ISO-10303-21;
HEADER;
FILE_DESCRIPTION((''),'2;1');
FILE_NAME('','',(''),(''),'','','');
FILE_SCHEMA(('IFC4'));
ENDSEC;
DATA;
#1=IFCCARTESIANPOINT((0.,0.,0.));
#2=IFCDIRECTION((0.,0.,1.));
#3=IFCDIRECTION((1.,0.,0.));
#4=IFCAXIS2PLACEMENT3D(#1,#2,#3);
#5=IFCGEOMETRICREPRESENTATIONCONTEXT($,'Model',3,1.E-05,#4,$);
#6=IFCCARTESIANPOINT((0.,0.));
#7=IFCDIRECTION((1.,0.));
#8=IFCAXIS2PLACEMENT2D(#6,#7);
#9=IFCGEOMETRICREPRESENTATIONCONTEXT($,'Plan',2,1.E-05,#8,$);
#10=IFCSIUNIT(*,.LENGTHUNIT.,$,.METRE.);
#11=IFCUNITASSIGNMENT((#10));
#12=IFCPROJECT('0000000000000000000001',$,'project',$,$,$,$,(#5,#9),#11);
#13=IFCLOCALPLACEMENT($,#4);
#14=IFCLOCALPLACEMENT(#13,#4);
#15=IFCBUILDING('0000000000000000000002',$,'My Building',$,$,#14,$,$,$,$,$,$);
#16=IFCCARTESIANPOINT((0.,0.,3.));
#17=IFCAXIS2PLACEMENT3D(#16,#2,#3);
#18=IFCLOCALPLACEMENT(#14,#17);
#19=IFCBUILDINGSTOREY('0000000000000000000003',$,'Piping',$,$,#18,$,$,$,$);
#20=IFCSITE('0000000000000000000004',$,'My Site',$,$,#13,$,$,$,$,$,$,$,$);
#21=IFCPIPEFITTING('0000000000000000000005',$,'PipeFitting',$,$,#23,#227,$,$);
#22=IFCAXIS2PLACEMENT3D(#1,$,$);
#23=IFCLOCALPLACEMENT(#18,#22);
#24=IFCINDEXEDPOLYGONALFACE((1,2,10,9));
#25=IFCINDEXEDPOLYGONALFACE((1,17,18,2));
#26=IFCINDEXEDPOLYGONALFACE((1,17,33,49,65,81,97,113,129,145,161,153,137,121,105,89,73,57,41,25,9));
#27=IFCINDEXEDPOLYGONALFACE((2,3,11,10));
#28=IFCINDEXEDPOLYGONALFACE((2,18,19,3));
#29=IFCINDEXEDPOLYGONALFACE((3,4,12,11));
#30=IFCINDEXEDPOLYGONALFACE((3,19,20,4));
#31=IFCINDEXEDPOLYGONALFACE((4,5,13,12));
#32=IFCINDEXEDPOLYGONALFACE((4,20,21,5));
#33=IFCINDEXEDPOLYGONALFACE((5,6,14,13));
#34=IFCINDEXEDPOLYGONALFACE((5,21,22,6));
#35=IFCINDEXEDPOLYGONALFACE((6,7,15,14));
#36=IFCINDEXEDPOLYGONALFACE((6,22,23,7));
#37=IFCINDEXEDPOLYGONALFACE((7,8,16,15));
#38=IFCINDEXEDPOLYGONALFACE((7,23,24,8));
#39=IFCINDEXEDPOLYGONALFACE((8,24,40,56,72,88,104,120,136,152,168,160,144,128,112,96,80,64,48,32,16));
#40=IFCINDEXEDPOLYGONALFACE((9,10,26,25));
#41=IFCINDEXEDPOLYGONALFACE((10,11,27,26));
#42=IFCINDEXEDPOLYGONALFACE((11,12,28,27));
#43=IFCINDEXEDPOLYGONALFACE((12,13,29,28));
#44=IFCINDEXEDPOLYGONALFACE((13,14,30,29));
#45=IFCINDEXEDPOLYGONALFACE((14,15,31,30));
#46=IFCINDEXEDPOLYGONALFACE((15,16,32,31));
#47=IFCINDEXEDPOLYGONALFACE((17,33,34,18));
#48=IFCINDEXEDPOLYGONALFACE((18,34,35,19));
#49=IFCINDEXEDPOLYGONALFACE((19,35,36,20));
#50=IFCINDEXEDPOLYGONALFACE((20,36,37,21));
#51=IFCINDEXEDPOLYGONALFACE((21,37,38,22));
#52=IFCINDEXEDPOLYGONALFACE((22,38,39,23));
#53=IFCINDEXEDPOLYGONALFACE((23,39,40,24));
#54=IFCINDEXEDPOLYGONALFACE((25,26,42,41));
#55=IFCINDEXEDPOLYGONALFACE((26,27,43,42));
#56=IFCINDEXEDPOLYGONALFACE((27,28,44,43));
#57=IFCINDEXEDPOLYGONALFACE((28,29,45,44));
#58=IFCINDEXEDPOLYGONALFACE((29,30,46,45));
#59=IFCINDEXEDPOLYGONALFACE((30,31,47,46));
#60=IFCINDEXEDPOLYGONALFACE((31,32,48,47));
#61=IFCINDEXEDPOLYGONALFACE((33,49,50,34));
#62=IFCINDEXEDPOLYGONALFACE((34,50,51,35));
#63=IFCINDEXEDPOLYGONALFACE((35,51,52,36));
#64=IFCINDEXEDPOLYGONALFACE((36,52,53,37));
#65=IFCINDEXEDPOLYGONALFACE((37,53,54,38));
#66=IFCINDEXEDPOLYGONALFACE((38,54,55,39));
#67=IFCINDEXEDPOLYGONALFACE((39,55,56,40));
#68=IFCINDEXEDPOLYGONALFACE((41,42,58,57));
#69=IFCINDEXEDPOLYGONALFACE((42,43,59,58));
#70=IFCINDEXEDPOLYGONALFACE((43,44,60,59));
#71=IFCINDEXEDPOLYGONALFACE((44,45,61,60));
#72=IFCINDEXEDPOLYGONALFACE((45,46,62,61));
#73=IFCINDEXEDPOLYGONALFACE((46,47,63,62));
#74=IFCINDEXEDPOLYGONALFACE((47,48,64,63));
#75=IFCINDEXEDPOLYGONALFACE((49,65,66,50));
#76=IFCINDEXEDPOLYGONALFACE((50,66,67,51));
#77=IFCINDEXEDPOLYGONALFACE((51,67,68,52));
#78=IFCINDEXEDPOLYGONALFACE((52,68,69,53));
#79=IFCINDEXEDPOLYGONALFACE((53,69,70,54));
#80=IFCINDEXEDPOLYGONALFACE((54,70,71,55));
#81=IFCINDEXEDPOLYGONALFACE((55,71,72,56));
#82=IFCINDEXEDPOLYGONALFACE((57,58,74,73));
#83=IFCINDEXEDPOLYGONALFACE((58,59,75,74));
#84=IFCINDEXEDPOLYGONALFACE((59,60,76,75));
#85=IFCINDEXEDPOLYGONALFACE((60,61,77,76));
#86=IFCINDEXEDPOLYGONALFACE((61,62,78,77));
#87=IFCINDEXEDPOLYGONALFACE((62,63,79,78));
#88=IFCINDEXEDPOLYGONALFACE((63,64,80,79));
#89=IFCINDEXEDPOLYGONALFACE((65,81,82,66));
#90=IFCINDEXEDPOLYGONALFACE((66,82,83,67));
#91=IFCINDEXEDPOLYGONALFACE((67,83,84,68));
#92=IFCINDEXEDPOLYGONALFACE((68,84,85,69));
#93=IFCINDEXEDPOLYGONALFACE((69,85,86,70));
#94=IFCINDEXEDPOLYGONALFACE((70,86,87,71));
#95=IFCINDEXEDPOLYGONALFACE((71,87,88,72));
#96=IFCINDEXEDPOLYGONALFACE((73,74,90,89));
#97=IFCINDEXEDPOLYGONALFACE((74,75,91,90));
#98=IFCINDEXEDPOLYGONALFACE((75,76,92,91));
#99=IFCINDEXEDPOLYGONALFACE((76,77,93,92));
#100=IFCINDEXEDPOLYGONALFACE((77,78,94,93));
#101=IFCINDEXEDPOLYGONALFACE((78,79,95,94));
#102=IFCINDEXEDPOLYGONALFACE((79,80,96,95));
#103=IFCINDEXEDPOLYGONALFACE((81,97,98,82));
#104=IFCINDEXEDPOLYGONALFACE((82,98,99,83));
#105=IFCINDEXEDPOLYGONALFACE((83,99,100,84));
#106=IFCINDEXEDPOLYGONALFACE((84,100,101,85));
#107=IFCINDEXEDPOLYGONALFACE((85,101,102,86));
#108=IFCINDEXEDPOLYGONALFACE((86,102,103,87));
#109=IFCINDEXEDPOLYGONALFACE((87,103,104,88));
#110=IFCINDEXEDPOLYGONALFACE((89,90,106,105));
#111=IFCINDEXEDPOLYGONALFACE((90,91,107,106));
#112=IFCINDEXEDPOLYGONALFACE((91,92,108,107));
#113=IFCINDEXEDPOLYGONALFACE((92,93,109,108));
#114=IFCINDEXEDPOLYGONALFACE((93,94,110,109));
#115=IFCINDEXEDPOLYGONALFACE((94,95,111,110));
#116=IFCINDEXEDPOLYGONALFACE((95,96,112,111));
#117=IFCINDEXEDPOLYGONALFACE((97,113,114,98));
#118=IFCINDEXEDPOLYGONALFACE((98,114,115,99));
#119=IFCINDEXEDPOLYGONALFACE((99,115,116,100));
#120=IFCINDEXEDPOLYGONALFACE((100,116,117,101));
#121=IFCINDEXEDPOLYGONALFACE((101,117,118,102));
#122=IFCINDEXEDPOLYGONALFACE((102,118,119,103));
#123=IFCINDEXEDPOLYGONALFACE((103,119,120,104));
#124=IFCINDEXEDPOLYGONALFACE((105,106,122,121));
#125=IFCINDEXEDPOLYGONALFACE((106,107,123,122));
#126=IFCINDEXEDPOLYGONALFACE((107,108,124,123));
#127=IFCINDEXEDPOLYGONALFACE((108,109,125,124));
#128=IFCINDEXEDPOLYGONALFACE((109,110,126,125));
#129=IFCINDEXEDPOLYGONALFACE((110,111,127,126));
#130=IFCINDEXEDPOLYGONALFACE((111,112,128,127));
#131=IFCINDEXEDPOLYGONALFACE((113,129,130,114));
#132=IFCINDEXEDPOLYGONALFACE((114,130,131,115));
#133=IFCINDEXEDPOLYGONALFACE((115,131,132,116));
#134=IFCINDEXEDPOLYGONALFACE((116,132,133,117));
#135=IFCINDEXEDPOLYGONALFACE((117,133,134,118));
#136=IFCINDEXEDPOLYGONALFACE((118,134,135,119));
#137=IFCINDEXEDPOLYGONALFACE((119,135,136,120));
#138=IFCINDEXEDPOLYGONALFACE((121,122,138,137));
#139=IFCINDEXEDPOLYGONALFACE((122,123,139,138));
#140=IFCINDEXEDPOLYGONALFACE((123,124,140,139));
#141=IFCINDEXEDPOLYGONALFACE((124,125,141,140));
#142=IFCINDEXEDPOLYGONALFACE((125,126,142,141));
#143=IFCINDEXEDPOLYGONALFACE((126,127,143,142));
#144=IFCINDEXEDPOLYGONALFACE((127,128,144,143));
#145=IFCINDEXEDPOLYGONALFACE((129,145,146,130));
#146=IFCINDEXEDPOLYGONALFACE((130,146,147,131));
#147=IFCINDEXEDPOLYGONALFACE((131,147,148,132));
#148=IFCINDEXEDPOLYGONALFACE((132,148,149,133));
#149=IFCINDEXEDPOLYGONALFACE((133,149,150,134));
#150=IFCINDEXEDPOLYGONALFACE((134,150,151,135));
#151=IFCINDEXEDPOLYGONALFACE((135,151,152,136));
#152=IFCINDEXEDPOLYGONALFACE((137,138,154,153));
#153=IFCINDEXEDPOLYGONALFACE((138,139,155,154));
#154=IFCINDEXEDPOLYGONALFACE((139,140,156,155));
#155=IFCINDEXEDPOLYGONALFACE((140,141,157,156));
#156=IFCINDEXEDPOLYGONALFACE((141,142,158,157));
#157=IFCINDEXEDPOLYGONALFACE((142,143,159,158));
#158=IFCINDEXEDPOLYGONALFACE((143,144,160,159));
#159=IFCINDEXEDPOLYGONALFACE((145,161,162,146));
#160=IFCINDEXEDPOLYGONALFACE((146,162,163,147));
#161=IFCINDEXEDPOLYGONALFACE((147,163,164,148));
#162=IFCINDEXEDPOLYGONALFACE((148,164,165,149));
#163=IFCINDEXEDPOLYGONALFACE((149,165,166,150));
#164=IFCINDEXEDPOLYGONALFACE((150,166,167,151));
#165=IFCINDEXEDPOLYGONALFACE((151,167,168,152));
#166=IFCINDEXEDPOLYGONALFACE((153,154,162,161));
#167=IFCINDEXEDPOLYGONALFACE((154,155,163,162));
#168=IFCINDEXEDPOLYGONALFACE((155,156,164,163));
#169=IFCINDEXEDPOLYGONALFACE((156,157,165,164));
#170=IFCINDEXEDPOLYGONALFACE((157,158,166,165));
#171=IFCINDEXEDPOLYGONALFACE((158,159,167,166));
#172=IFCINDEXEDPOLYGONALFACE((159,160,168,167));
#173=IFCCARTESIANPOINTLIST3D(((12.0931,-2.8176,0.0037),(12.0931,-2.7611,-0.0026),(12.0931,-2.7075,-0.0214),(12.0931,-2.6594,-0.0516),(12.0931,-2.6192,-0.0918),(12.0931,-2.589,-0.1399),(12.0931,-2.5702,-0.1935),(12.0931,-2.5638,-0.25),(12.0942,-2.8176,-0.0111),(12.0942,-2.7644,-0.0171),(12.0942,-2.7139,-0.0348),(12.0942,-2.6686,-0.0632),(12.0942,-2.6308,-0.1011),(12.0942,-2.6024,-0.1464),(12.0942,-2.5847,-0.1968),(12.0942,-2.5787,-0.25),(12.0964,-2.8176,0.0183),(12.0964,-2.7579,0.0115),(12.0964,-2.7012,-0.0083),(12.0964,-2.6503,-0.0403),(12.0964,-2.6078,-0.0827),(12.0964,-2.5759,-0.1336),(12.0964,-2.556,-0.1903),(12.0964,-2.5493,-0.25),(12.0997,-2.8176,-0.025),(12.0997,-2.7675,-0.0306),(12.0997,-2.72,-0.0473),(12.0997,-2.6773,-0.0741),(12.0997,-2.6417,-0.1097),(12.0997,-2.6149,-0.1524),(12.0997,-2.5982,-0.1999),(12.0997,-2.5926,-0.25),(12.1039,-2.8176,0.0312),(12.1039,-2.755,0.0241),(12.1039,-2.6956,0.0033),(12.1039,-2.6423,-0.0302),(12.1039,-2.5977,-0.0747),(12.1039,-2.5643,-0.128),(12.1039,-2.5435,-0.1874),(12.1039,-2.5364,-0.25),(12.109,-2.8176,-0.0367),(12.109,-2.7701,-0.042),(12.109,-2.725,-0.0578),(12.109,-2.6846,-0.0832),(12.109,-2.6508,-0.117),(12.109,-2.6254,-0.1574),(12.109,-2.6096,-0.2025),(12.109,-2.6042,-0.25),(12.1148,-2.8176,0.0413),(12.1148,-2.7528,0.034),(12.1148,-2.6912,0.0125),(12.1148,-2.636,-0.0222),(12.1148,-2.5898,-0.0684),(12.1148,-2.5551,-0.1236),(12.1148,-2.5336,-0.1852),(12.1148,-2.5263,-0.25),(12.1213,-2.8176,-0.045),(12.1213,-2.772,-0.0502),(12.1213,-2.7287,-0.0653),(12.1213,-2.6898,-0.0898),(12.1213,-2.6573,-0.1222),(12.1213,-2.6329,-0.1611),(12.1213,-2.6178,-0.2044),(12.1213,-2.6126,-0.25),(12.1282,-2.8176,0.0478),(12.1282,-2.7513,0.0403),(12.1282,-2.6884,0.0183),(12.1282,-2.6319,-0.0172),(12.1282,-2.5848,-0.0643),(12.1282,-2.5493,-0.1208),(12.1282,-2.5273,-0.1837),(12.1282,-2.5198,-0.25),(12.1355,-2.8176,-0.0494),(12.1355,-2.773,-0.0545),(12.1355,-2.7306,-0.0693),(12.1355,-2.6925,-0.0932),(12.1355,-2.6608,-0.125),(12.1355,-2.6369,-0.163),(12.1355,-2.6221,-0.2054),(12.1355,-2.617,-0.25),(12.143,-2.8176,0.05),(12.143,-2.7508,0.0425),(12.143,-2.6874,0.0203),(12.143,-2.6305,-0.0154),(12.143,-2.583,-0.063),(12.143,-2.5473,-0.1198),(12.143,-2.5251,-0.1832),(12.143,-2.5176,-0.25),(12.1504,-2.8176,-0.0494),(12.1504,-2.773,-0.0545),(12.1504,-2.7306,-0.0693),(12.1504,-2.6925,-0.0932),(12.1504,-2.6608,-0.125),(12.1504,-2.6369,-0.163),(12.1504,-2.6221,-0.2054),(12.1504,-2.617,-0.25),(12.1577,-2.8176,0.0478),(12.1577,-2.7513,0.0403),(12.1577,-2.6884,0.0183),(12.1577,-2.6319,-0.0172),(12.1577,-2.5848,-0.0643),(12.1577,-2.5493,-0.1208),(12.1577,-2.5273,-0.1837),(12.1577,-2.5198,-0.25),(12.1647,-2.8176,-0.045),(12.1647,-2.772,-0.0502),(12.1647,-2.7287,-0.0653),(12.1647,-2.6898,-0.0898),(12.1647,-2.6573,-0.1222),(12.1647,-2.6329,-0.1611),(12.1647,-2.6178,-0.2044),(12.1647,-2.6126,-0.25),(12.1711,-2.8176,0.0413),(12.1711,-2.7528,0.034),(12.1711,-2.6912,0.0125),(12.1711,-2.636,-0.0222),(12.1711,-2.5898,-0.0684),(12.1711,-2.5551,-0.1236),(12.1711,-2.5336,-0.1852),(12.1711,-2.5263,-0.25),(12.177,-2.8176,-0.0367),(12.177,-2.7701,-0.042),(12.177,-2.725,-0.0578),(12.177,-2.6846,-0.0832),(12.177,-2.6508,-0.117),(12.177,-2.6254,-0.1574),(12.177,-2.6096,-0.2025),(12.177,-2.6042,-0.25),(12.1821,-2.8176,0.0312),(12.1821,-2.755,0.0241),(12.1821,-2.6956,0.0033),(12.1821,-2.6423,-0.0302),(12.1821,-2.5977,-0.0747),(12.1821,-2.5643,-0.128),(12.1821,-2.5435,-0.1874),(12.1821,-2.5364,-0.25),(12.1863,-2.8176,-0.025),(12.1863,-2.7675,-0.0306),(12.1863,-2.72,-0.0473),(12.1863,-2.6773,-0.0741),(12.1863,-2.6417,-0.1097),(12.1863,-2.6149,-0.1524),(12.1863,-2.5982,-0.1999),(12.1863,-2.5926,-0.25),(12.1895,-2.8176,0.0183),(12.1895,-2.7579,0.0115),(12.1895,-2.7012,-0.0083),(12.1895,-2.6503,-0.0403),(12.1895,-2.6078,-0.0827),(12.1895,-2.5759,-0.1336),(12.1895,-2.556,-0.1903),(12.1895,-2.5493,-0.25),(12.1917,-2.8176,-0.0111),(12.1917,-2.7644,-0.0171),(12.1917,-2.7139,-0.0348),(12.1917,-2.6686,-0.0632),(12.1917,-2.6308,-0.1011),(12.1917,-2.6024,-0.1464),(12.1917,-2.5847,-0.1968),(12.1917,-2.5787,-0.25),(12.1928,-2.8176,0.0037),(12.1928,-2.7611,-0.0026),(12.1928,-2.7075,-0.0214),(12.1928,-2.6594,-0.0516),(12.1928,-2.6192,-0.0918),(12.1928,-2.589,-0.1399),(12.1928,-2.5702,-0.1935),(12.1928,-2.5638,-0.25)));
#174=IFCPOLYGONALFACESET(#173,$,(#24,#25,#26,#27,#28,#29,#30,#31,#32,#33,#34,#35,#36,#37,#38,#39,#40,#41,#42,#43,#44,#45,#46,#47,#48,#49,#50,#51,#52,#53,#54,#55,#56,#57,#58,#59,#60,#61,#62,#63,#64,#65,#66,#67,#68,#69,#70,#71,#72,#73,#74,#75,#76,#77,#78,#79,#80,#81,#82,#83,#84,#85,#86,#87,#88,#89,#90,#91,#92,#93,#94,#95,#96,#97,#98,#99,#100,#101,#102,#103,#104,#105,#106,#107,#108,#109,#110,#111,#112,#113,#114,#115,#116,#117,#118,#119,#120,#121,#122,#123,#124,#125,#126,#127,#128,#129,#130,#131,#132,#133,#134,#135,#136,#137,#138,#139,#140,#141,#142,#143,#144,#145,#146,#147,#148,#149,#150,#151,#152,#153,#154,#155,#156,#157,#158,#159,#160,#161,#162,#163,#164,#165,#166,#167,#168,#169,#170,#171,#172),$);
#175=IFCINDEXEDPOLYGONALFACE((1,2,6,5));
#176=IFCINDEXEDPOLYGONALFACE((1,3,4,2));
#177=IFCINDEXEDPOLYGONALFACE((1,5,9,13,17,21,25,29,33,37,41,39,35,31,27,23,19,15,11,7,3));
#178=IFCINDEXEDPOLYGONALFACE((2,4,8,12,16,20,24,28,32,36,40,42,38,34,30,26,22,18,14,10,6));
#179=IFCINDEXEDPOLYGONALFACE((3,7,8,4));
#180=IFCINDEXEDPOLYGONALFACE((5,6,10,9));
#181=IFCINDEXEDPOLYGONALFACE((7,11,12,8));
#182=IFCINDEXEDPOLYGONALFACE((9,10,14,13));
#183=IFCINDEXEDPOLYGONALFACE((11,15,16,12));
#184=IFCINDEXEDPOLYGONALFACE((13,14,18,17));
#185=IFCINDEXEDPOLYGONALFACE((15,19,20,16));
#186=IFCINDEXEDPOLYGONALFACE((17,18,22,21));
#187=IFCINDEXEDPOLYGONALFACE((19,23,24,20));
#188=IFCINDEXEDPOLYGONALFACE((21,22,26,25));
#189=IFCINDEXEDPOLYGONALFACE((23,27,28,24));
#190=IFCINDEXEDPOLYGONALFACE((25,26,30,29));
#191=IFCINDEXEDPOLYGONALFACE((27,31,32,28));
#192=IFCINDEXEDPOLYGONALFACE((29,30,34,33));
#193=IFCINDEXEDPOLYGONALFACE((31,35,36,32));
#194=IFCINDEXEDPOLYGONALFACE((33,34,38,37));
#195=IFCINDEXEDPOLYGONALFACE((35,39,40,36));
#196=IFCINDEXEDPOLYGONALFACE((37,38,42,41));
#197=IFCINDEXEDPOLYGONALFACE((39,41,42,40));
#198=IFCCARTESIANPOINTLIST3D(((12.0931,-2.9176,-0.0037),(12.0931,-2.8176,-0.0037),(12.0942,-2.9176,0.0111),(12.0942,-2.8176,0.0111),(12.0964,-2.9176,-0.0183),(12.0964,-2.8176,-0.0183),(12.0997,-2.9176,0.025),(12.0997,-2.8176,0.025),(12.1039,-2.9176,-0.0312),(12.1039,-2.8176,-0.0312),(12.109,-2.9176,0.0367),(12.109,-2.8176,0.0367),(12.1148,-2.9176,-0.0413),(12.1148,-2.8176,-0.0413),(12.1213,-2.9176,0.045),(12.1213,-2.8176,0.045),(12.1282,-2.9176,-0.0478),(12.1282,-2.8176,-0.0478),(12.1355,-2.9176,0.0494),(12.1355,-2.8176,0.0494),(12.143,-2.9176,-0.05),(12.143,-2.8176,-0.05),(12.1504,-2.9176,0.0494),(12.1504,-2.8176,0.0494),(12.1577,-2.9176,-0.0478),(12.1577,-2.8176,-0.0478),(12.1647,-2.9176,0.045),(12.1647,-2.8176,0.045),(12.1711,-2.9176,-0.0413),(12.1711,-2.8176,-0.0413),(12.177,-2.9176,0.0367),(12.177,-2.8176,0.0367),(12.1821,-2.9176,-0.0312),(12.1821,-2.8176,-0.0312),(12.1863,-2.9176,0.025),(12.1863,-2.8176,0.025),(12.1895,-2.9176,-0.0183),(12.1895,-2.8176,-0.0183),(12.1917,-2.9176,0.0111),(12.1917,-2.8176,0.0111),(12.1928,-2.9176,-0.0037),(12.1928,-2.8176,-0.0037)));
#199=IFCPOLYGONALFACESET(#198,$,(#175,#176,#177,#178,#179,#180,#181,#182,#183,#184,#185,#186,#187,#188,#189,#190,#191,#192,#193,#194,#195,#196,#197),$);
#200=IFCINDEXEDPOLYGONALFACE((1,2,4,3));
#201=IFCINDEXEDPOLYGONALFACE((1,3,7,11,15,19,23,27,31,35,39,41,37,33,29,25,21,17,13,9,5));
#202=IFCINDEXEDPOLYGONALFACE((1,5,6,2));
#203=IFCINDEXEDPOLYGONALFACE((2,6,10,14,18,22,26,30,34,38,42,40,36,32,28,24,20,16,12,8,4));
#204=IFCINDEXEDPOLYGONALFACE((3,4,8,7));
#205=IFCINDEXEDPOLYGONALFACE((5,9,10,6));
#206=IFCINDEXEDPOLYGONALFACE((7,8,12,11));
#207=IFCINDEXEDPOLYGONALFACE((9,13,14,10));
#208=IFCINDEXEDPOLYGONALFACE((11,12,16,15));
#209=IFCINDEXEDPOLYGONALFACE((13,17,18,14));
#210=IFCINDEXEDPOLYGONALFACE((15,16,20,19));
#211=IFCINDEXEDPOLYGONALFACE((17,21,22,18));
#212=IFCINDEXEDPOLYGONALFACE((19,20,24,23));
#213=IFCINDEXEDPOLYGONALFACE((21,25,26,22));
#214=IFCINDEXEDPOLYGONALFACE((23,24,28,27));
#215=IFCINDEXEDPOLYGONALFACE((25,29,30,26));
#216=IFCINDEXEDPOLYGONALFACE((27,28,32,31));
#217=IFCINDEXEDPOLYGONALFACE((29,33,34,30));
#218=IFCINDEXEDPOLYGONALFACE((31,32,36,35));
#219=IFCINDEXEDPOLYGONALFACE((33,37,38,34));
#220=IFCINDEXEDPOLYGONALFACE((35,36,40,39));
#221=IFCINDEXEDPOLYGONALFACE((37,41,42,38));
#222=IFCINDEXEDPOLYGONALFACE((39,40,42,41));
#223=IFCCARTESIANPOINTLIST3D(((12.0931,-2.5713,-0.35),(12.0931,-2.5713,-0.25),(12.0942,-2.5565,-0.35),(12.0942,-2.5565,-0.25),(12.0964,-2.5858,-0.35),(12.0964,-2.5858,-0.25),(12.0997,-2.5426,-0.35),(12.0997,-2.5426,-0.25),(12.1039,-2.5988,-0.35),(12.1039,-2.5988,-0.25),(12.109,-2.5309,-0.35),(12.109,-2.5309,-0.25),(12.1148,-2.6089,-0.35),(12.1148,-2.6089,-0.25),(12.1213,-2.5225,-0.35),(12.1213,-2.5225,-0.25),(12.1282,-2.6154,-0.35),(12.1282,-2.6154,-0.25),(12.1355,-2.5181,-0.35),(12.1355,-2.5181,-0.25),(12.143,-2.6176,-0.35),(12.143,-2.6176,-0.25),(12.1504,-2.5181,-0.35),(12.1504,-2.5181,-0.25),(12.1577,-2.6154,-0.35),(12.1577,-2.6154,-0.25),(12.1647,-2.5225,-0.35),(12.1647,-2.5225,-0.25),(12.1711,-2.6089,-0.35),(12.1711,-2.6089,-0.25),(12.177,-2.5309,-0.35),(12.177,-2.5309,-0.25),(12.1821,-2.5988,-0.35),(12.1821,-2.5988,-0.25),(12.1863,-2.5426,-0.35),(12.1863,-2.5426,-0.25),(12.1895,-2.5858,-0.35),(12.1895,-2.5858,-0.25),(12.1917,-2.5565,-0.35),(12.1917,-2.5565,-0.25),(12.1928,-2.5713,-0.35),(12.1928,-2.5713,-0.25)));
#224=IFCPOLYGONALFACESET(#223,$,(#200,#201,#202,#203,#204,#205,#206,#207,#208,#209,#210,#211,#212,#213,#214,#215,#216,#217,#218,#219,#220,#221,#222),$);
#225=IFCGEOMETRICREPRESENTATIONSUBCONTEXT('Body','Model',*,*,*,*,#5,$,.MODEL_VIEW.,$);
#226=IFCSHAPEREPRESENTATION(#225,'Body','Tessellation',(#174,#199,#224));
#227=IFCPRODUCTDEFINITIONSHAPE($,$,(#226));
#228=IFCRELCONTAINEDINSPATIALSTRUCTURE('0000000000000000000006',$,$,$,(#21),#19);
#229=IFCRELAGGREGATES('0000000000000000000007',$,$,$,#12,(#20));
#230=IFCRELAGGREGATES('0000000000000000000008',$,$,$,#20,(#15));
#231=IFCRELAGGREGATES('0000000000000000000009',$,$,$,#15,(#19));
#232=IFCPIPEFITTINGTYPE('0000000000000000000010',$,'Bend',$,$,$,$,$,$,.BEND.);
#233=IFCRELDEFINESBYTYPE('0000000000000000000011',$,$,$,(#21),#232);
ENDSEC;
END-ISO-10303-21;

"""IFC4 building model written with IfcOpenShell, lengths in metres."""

from ifc_helpers import new_model, entity, si_unit, frame, origin_with_axes, origin_2d_with_axis, place, context, subcontext, project, spatial, circle, extrude, source, transform, mapped, type_object, type_shapes, element, save


model = new_model("IFC4")

# Units and contexts
model_context = context("Model", 3, precision=1e-05, world=origin_with_axes())
plan_context = context("Plan", 2, precision=1e-05, world=origin_2d_with_axis())
body_context = subcontext(model_context, "Body", "Model", "MODEL_VIEW")
ifc_project = project(units=[si_unit("LENGTHUNIT", "METRE")], contexts=[model_context, plan_context])

# Site, building, storey
site_placement = place(None, origin_with_axes())
site = spatial("IfcSite", under=ifc_project, at=site_placement, Name="My Site")
building_placement = place(site_placement, origin_with_axes())
building = spatial("IfcBuilding", under=site, at=building_placement, Name="My Building")
storey_placement = place(building_placement, frame((0.0, 0.0, 3.0), z_axis=(0.0, 0.0, 1.0), x_axis=(1.0, 0.0, 0.0)))
storey = spatial("IfcBuildingStorey", under=building, at=storey_placement, Name="Piping")

# Pipe fitting
pipe_fitting_type_1 = type_object("IfcPipeFittingType", Name="Bend", PredefinedType="BEND")
shared_shape_1 = source(origin_with_axes(), body_context, "Body", "SolidModel", [
    entity("IfcSweptDiskSolid", entity("IfcIndexedPolyCurve", entity("IfcCartesianPointList3D", [[0.0, 0.0, -0.1], [0.0732, 0.0, -0.2768], [0.25, 0.0, -0.35]]), [entity("IfcArcIndex", [1, 2, 3])]), 0.05),
    extrude(circle(Radius=0.05), origin_with_axes(), (0.0, 0.0, -1.0), 0.1),
    extrude(circle(Radius=0.05), frame((0.25, 0.0, -0.35), z_axis=(1.0, 0.0, 0.0), x_axis=(0.0, 0.0, 1.0)), (0.0, 0.0, 1.0), 0.1),
])
type_shapes(pipe_fitting_type_1, [shared_shape_1])
for number, where, z_axis, x_axis, name in (
    (1, (12.143, -2.9176, 0.0), (0.0, -1.0, 0.0), (0.0, 0.0, -1.0), "PipeFitting"),
):
    element("IfcPipeFitting", number, at=place(storey_placement, frame(where, z_axis=z_axis, x_axis=x_axis)), inside=storey, type_object=pipe_fitting_type_1, Name=name, context=body_context, shape_type="MappedRepresentation", body=[
        mapped(shared_shape_1, transform((0.0, 0.0, 0.0), x_axis=(1.0, 0.0, 0.0), y_axis=(0.0, 1.0, 0.0), z_axis=(0.0, 0.0, 1.0), scale=1.0)),
    ])

save(model, "model.ifc")
